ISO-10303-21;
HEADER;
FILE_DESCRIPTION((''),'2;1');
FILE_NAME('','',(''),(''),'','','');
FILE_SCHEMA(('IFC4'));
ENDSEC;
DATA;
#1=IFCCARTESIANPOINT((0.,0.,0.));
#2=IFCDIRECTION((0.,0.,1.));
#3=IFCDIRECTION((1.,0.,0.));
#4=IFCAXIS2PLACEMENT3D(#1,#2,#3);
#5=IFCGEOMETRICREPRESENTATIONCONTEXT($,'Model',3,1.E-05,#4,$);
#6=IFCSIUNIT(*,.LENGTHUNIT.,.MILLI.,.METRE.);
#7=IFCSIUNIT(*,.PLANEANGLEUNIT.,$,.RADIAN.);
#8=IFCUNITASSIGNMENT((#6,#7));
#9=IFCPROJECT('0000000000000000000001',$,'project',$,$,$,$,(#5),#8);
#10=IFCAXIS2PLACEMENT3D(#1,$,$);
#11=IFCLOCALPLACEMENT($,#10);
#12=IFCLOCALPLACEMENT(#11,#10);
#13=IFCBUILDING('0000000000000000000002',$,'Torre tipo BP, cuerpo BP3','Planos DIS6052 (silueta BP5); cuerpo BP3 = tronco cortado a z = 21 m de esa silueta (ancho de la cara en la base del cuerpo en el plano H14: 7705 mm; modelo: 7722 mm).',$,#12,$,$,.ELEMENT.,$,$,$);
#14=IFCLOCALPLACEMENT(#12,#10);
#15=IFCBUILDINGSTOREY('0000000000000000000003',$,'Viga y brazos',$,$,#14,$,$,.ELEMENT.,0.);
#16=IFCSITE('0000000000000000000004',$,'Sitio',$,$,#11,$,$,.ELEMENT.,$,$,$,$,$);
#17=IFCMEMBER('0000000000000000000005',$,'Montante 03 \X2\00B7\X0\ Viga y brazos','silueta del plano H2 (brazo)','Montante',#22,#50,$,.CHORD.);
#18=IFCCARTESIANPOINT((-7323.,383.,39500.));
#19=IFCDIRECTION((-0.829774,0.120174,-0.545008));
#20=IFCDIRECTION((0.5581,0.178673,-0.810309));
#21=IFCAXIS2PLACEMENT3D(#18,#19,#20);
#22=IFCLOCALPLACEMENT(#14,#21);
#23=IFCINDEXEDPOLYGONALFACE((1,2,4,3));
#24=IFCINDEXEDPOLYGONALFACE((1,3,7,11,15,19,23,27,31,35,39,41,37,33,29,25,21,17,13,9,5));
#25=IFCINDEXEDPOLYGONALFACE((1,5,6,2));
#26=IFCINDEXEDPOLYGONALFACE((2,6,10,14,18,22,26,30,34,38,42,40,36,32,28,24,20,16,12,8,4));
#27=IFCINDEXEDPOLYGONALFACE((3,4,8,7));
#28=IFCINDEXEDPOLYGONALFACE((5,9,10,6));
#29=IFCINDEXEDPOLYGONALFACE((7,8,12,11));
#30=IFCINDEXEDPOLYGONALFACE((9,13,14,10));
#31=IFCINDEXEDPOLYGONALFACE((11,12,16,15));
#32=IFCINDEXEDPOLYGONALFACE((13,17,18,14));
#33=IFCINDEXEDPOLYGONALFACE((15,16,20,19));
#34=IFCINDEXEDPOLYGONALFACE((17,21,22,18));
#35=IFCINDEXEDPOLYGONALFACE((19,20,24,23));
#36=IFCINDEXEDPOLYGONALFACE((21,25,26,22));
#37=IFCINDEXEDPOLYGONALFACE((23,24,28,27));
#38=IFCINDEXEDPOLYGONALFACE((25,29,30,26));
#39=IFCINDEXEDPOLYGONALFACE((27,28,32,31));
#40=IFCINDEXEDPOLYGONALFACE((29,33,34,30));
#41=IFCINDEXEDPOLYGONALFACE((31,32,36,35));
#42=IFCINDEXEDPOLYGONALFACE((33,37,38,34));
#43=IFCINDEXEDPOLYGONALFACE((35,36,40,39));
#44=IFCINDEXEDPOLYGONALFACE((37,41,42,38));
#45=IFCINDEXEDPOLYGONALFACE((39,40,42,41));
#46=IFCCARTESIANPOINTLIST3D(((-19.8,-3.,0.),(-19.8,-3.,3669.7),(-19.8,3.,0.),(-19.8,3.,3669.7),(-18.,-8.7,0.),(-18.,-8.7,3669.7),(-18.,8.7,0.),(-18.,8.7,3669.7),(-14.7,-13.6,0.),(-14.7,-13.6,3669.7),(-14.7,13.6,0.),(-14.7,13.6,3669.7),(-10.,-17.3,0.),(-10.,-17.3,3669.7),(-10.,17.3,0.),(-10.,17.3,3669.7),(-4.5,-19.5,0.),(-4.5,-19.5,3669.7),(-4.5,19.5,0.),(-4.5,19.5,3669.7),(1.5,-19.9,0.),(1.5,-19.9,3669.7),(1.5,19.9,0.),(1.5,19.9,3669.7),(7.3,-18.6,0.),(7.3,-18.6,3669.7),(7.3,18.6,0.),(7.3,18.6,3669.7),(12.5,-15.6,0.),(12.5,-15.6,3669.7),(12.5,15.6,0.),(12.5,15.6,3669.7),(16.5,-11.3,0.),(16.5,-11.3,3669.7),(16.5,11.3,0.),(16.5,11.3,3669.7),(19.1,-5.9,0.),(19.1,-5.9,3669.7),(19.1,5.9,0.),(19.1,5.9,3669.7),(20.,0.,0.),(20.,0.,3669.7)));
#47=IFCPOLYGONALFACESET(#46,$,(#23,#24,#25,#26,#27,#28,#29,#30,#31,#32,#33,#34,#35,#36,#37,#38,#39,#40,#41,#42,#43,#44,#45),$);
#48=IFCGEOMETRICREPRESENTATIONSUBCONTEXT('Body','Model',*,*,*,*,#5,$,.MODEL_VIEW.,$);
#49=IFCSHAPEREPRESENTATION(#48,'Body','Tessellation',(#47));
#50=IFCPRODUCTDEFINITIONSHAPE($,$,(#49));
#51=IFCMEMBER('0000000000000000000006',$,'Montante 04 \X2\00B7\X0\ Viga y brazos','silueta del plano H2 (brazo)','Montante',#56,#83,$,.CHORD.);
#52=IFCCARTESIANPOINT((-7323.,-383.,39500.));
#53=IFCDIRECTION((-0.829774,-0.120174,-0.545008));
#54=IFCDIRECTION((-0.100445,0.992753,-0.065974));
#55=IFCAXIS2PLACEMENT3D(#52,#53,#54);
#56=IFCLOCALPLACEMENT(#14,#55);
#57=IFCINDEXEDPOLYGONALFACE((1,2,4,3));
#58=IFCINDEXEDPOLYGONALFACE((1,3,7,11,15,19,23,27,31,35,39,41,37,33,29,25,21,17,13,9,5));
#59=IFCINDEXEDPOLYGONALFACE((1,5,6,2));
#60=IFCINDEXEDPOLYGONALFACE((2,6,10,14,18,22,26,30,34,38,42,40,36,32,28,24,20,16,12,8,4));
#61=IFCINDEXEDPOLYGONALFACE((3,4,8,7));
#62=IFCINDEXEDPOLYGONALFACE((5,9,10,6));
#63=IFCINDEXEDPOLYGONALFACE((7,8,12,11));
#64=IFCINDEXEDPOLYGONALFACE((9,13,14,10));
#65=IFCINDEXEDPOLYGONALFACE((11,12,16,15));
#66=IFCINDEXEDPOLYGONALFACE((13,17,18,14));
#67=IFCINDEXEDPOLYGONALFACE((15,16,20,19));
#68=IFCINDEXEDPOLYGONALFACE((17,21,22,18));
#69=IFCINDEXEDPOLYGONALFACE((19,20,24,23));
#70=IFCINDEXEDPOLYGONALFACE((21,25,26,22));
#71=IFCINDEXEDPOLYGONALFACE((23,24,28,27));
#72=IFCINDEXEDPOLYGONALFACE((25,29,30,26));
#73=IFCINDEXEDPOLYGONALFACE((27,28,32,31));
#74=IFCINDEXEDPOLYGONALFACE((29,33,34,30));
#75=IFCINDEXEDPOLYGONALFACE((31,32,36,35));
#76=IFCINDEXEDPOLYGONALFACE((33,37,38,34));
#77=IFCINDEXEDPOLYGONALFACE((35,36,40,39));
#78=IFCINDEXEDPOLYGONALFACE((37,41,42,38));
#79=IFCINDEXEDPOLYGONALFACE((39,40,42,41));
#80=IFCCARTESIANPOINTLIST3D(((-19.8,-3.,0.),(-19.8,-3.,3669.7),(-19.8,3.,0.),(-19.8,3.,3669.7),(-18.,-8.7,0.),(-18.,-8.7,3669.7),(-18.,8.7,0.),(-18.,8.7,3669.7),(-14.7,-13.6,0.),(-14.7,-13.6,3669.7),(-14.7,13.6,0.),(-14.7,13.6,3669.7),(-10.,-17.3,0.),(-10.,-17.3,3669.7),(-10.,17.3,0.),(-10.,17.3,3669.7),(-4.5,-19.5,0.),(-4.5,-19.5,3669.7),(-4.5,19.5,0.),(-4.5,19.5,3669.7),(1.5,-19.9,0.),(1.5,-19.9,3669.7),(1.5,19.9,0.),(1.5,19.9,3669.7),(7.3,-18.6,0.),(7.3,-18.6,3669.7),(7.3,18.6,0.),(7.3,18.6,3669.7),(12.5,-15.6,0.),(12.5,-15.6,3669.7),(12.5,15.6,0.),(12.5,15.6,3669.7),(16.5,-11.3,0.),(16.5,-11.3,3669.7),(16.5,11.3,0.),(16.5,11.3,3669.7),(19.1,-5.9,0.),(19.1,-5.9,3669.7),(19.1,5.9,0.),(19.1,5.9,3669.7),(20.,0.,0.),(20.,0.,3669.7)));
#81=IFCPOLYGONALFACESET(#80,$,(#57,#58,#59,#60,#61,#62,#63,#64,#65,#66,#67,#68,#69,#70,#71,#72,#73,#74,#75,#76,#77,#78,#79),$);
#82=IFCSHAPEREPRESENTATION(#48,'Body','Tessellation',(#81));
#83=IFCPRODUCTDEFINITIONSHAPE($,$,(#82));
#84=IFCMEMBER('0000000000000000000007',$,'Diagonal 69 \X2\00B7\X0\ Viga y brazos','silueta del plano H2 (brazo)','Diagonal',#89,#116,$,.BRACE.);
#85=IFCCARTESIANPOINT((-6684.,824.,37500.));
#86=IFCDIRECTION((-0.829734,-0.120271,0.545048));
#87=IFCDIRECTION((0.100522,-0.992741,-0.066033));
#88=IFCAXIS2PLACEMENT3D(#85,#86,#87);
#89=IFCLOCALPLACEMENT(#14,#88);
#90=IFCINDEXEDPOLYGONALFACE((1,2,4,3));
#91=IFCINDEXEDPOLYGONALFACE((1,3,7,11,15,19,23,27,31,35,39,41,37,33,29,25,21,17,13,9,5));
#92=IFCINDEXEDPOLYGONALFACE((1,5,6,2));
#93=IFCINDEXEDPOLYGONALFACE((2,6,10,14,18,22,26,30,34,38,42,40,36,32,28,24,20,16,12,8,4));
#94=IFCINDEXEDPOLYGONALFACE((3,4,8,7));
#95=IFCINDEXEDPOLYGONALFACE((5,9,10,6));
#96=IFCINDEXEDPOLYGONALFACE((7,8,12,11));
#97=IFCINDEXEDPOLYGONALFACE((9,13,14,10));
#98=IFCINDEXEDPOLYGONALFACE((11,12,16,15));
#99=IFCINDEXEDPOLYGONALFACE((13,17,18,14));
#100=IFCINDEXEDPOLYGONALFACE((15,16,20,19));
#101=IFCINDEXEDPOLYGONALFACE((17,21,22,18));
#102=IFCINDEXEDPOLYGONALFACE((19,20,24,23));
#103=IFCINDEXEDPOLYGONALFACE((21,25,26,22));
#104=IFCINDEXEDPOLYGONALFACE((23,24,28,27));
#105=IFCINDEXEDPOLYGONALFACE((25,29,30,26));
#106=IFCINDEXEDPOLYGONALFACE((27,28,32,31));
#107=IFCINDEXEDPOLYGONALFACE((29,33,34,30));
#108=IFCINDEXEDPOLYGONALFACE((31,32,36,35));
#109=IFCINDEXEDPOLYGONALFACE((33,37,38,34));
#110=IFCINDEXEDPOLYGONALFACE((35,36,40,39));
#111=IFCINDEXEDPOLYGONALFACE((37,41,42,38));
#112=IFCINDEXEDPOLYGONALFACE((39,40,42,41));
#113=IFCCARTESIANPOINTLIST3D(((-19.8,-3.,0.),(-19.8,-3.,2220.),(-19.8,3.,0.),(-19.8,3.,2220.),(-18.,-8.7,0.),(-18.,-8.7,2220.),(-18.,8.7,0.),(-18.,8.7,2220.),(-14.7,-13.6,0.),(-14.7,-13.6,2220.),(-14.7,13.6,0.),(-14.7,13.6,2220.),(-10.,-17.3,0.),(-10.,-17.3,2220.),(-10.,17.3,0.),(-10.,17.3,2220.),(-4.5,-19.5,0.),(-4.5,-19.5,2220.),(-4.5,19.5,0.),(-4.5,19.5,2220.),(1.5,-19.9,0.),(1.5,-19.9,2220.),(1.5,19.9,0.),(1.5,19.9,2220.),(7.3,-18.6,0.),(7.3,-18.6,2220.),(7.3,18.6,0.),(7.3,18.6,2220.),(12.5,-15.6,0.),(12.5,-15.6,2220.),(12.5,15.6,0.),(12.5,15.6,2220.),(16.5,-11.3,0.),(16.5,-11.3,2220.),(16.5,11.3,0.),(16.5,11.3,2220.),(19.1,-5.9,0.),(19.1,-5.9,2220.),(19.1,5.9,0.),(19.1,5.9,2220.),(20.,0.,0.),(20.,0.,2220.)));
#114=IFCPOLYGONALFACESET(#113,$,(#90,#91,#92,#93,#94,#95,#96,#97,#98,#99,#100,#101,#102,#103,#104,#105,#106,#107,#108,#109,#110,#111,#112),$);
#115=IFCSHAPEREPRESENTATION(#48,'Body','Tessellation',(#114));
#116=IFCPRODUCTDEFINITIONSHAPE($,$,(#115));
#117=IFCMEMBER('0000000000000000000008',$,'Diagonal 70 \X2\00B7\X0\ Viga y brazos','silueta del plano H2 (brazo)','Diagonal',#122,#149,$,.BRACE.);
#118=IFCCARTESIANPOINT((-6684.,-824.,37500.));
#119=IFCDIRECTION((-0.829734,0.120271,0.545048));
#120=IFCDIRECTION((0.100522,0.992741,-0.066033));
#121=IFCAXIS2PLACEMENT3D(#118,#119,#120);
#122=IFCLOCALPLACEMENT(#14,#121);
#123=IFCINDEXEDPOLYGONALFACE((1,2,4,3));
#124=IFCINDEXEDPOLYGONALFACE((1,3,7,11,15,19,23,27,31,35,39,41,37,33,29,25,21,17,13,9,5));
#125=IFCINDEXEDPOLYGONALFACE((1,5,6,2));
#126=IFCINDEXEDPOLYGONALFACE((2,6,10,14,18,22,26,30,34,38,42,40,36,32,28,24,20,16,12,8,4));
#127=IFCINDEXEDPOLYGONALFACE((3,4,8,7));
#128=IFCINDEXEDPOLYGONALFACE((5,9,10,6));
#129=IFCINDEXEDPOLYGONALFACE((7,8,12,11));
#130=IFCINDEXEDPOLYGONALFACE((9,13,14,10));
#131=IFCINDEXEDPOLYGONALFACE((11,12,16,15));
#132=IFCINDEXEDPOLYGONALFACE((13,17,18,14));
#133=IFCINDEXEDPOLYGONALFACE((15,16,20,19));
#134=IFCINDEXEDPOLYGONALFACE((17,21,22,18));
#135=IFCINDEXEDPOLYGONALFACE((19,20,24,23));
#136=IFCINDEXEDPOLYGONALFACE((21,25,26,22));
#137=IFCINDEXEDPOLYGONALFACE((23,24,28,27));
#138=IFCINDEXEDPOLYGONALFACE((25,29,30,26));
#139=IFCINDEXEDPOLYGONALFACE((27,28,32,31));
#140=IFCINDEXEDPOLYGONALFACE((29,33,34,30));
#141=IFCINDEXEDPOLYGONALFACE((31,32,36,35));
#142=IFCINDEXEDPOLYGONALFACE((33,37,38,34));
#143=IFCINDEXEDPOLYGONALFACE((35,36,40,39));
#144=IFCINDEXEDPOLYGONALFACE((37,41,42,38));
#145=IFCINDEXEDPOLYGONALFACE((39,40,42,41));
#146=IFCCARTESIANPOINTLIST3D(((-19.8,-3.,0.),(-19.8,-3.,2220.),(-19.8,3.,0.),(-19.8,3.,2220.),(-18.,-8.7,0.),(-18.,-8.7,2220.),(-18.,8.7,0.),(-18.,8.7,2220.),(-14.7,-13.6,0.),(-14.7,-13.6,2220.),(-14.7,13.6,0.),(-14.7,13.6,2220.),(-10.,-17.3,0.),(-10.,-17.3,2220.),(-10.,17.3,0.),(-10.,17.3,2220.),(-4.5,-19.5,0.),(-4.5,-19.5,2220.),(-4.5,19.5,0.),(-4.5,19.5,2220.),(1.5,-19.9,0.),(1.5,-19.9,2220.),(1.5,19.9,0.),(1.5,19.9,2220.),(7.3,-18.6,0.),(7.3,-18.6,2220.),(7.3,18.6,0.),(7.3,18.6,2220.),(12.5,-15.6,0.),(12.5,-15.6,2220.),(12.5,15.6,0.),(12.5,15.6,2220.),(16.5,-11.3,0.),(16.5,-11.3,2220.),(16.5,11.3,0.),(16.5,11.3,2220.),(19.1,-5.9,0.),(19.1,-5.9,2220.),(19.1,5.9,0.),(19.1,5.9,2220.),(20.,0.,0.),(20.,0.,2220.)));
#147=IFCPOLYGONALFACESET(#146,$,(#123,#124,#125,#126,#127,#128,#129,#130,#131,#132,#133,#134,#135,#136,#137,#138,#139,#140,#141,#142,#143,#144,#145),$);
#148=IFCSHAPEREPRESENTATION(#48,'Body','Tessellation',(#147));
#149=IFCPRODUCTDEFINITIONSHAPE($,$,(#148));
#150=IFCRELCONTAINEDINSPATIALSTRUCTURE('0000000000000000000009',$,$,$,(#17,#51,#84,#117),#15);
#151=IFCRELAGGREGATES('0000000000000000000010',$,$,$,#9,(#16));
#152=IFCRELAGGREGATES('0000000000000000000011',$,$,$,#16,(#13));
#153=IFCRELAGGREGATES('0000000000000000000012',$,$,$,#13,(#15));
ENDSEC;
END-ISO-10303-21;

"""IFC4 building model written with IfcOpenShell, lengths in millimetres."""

from ifc_helpers import new_model, si_unit, frame, origin, origin_with_axes, place, context, subcontext, project, spatial, circle, extrude, element, save


model = new_model("IFC4")

# Units and contexts
model_context = context("Model", 3, precision=1e-05, world=origin_with_axes())
body_context = subcontext(model_context, "Body", "Model", "MODEL_VIEW")
ifc_project = project(units=[si_unit("LENGTHUNIT", "METRE", prefix="MILLI"), si_unit("PLANEANGLEUNIT", "RADIAN")], contexts=[model_context])

# Site, building, storey
site_placement = place(None, origin())
site = spatial("IfcSite", under=ifc_project, at=site_placement, Name="Sitio", CompositionType="ELEMENT")
building_placement = place(site_placement, origin())
building = spatial("IfcBuilding", under=site, at=building_placement, Name="Torre tipo BP, cuerpo BP3", Description="Planos DIS6052 (silueta BP5); cuerpo BP3 = tronco cortado a z = 21 m de esa silueta (ancho de la cara en la base del cuerpo en el plano H14: 7705 mm; modelo: 7722 mm).", CompositionType="ELEMENT")
storey_placement = place(building_placement, origin())
storey = spatial("IfcBuildingStorey", under=building, at=storey_placement, Name="Viga y brazos", CompositionType="ELEMENT", Elevation=0.0)

# Members
for number, where, z_axis, x_axis, name in (
    (1, (-7323.0, 383.0, 39500.0), (-0.829774, 0.120174, -0.545008), (0.5581, 0.178673, -0.810309), "Montante 03 · Viga y brazos"),
    (2, (-7323.0, -383.0, 39500.0), (-0.829774, -0.120174, -0.545008), (-0.100445, 0.992753, -0.065974), "Montante 04 · Viga y brazos"),
):
    element("IfcMember", number, at=place(storey_placement, frame(where, z_axis=z_axis, x_axis=x_axis)), inside=storey, Name=name, Description="silueta del plano H2 (brazo)", ObjectType="Montante", PredefinedType="CHORD", context=body_context, shape_type="SweptSolid", body=[
        extrude(circle(Radius=20.0), None, (0.0, 0.0, 1.0), 3669.7),
    ])
for number, where, z_axis, x_axis, name in (
    (3, (-6684.0, 824.0, 37500.0), (-0.829734, -0.120271, 0.545048), (0.100522, -0.992741, -0.066033), "Diagonal 69 · Viga y brazos"),
    (4, (-6684.0, -824.0, 37500.0), (-0.829734, 0.120271, 0.545048), (0.100522, 0.992741, -0.066033), "Diagonal 70 · Viga y brazos"),
):
    element("IfcMember", number, at=place(storey_placement, frame(where, z_axis=z_axis, x_axis=x_axis)), inside=storey, Name=name, Description="silueta del plano H2 (brazo)", ObjectType="Diagonal", PredefinedType="BRACE", context=body_context, shape_type="SweptSolid", body=[
        extrude(circle(Radius=20.0), None, (0.0, 0.0, 1.0), 2220.0),
    ])

save(model, "model.ifc")
